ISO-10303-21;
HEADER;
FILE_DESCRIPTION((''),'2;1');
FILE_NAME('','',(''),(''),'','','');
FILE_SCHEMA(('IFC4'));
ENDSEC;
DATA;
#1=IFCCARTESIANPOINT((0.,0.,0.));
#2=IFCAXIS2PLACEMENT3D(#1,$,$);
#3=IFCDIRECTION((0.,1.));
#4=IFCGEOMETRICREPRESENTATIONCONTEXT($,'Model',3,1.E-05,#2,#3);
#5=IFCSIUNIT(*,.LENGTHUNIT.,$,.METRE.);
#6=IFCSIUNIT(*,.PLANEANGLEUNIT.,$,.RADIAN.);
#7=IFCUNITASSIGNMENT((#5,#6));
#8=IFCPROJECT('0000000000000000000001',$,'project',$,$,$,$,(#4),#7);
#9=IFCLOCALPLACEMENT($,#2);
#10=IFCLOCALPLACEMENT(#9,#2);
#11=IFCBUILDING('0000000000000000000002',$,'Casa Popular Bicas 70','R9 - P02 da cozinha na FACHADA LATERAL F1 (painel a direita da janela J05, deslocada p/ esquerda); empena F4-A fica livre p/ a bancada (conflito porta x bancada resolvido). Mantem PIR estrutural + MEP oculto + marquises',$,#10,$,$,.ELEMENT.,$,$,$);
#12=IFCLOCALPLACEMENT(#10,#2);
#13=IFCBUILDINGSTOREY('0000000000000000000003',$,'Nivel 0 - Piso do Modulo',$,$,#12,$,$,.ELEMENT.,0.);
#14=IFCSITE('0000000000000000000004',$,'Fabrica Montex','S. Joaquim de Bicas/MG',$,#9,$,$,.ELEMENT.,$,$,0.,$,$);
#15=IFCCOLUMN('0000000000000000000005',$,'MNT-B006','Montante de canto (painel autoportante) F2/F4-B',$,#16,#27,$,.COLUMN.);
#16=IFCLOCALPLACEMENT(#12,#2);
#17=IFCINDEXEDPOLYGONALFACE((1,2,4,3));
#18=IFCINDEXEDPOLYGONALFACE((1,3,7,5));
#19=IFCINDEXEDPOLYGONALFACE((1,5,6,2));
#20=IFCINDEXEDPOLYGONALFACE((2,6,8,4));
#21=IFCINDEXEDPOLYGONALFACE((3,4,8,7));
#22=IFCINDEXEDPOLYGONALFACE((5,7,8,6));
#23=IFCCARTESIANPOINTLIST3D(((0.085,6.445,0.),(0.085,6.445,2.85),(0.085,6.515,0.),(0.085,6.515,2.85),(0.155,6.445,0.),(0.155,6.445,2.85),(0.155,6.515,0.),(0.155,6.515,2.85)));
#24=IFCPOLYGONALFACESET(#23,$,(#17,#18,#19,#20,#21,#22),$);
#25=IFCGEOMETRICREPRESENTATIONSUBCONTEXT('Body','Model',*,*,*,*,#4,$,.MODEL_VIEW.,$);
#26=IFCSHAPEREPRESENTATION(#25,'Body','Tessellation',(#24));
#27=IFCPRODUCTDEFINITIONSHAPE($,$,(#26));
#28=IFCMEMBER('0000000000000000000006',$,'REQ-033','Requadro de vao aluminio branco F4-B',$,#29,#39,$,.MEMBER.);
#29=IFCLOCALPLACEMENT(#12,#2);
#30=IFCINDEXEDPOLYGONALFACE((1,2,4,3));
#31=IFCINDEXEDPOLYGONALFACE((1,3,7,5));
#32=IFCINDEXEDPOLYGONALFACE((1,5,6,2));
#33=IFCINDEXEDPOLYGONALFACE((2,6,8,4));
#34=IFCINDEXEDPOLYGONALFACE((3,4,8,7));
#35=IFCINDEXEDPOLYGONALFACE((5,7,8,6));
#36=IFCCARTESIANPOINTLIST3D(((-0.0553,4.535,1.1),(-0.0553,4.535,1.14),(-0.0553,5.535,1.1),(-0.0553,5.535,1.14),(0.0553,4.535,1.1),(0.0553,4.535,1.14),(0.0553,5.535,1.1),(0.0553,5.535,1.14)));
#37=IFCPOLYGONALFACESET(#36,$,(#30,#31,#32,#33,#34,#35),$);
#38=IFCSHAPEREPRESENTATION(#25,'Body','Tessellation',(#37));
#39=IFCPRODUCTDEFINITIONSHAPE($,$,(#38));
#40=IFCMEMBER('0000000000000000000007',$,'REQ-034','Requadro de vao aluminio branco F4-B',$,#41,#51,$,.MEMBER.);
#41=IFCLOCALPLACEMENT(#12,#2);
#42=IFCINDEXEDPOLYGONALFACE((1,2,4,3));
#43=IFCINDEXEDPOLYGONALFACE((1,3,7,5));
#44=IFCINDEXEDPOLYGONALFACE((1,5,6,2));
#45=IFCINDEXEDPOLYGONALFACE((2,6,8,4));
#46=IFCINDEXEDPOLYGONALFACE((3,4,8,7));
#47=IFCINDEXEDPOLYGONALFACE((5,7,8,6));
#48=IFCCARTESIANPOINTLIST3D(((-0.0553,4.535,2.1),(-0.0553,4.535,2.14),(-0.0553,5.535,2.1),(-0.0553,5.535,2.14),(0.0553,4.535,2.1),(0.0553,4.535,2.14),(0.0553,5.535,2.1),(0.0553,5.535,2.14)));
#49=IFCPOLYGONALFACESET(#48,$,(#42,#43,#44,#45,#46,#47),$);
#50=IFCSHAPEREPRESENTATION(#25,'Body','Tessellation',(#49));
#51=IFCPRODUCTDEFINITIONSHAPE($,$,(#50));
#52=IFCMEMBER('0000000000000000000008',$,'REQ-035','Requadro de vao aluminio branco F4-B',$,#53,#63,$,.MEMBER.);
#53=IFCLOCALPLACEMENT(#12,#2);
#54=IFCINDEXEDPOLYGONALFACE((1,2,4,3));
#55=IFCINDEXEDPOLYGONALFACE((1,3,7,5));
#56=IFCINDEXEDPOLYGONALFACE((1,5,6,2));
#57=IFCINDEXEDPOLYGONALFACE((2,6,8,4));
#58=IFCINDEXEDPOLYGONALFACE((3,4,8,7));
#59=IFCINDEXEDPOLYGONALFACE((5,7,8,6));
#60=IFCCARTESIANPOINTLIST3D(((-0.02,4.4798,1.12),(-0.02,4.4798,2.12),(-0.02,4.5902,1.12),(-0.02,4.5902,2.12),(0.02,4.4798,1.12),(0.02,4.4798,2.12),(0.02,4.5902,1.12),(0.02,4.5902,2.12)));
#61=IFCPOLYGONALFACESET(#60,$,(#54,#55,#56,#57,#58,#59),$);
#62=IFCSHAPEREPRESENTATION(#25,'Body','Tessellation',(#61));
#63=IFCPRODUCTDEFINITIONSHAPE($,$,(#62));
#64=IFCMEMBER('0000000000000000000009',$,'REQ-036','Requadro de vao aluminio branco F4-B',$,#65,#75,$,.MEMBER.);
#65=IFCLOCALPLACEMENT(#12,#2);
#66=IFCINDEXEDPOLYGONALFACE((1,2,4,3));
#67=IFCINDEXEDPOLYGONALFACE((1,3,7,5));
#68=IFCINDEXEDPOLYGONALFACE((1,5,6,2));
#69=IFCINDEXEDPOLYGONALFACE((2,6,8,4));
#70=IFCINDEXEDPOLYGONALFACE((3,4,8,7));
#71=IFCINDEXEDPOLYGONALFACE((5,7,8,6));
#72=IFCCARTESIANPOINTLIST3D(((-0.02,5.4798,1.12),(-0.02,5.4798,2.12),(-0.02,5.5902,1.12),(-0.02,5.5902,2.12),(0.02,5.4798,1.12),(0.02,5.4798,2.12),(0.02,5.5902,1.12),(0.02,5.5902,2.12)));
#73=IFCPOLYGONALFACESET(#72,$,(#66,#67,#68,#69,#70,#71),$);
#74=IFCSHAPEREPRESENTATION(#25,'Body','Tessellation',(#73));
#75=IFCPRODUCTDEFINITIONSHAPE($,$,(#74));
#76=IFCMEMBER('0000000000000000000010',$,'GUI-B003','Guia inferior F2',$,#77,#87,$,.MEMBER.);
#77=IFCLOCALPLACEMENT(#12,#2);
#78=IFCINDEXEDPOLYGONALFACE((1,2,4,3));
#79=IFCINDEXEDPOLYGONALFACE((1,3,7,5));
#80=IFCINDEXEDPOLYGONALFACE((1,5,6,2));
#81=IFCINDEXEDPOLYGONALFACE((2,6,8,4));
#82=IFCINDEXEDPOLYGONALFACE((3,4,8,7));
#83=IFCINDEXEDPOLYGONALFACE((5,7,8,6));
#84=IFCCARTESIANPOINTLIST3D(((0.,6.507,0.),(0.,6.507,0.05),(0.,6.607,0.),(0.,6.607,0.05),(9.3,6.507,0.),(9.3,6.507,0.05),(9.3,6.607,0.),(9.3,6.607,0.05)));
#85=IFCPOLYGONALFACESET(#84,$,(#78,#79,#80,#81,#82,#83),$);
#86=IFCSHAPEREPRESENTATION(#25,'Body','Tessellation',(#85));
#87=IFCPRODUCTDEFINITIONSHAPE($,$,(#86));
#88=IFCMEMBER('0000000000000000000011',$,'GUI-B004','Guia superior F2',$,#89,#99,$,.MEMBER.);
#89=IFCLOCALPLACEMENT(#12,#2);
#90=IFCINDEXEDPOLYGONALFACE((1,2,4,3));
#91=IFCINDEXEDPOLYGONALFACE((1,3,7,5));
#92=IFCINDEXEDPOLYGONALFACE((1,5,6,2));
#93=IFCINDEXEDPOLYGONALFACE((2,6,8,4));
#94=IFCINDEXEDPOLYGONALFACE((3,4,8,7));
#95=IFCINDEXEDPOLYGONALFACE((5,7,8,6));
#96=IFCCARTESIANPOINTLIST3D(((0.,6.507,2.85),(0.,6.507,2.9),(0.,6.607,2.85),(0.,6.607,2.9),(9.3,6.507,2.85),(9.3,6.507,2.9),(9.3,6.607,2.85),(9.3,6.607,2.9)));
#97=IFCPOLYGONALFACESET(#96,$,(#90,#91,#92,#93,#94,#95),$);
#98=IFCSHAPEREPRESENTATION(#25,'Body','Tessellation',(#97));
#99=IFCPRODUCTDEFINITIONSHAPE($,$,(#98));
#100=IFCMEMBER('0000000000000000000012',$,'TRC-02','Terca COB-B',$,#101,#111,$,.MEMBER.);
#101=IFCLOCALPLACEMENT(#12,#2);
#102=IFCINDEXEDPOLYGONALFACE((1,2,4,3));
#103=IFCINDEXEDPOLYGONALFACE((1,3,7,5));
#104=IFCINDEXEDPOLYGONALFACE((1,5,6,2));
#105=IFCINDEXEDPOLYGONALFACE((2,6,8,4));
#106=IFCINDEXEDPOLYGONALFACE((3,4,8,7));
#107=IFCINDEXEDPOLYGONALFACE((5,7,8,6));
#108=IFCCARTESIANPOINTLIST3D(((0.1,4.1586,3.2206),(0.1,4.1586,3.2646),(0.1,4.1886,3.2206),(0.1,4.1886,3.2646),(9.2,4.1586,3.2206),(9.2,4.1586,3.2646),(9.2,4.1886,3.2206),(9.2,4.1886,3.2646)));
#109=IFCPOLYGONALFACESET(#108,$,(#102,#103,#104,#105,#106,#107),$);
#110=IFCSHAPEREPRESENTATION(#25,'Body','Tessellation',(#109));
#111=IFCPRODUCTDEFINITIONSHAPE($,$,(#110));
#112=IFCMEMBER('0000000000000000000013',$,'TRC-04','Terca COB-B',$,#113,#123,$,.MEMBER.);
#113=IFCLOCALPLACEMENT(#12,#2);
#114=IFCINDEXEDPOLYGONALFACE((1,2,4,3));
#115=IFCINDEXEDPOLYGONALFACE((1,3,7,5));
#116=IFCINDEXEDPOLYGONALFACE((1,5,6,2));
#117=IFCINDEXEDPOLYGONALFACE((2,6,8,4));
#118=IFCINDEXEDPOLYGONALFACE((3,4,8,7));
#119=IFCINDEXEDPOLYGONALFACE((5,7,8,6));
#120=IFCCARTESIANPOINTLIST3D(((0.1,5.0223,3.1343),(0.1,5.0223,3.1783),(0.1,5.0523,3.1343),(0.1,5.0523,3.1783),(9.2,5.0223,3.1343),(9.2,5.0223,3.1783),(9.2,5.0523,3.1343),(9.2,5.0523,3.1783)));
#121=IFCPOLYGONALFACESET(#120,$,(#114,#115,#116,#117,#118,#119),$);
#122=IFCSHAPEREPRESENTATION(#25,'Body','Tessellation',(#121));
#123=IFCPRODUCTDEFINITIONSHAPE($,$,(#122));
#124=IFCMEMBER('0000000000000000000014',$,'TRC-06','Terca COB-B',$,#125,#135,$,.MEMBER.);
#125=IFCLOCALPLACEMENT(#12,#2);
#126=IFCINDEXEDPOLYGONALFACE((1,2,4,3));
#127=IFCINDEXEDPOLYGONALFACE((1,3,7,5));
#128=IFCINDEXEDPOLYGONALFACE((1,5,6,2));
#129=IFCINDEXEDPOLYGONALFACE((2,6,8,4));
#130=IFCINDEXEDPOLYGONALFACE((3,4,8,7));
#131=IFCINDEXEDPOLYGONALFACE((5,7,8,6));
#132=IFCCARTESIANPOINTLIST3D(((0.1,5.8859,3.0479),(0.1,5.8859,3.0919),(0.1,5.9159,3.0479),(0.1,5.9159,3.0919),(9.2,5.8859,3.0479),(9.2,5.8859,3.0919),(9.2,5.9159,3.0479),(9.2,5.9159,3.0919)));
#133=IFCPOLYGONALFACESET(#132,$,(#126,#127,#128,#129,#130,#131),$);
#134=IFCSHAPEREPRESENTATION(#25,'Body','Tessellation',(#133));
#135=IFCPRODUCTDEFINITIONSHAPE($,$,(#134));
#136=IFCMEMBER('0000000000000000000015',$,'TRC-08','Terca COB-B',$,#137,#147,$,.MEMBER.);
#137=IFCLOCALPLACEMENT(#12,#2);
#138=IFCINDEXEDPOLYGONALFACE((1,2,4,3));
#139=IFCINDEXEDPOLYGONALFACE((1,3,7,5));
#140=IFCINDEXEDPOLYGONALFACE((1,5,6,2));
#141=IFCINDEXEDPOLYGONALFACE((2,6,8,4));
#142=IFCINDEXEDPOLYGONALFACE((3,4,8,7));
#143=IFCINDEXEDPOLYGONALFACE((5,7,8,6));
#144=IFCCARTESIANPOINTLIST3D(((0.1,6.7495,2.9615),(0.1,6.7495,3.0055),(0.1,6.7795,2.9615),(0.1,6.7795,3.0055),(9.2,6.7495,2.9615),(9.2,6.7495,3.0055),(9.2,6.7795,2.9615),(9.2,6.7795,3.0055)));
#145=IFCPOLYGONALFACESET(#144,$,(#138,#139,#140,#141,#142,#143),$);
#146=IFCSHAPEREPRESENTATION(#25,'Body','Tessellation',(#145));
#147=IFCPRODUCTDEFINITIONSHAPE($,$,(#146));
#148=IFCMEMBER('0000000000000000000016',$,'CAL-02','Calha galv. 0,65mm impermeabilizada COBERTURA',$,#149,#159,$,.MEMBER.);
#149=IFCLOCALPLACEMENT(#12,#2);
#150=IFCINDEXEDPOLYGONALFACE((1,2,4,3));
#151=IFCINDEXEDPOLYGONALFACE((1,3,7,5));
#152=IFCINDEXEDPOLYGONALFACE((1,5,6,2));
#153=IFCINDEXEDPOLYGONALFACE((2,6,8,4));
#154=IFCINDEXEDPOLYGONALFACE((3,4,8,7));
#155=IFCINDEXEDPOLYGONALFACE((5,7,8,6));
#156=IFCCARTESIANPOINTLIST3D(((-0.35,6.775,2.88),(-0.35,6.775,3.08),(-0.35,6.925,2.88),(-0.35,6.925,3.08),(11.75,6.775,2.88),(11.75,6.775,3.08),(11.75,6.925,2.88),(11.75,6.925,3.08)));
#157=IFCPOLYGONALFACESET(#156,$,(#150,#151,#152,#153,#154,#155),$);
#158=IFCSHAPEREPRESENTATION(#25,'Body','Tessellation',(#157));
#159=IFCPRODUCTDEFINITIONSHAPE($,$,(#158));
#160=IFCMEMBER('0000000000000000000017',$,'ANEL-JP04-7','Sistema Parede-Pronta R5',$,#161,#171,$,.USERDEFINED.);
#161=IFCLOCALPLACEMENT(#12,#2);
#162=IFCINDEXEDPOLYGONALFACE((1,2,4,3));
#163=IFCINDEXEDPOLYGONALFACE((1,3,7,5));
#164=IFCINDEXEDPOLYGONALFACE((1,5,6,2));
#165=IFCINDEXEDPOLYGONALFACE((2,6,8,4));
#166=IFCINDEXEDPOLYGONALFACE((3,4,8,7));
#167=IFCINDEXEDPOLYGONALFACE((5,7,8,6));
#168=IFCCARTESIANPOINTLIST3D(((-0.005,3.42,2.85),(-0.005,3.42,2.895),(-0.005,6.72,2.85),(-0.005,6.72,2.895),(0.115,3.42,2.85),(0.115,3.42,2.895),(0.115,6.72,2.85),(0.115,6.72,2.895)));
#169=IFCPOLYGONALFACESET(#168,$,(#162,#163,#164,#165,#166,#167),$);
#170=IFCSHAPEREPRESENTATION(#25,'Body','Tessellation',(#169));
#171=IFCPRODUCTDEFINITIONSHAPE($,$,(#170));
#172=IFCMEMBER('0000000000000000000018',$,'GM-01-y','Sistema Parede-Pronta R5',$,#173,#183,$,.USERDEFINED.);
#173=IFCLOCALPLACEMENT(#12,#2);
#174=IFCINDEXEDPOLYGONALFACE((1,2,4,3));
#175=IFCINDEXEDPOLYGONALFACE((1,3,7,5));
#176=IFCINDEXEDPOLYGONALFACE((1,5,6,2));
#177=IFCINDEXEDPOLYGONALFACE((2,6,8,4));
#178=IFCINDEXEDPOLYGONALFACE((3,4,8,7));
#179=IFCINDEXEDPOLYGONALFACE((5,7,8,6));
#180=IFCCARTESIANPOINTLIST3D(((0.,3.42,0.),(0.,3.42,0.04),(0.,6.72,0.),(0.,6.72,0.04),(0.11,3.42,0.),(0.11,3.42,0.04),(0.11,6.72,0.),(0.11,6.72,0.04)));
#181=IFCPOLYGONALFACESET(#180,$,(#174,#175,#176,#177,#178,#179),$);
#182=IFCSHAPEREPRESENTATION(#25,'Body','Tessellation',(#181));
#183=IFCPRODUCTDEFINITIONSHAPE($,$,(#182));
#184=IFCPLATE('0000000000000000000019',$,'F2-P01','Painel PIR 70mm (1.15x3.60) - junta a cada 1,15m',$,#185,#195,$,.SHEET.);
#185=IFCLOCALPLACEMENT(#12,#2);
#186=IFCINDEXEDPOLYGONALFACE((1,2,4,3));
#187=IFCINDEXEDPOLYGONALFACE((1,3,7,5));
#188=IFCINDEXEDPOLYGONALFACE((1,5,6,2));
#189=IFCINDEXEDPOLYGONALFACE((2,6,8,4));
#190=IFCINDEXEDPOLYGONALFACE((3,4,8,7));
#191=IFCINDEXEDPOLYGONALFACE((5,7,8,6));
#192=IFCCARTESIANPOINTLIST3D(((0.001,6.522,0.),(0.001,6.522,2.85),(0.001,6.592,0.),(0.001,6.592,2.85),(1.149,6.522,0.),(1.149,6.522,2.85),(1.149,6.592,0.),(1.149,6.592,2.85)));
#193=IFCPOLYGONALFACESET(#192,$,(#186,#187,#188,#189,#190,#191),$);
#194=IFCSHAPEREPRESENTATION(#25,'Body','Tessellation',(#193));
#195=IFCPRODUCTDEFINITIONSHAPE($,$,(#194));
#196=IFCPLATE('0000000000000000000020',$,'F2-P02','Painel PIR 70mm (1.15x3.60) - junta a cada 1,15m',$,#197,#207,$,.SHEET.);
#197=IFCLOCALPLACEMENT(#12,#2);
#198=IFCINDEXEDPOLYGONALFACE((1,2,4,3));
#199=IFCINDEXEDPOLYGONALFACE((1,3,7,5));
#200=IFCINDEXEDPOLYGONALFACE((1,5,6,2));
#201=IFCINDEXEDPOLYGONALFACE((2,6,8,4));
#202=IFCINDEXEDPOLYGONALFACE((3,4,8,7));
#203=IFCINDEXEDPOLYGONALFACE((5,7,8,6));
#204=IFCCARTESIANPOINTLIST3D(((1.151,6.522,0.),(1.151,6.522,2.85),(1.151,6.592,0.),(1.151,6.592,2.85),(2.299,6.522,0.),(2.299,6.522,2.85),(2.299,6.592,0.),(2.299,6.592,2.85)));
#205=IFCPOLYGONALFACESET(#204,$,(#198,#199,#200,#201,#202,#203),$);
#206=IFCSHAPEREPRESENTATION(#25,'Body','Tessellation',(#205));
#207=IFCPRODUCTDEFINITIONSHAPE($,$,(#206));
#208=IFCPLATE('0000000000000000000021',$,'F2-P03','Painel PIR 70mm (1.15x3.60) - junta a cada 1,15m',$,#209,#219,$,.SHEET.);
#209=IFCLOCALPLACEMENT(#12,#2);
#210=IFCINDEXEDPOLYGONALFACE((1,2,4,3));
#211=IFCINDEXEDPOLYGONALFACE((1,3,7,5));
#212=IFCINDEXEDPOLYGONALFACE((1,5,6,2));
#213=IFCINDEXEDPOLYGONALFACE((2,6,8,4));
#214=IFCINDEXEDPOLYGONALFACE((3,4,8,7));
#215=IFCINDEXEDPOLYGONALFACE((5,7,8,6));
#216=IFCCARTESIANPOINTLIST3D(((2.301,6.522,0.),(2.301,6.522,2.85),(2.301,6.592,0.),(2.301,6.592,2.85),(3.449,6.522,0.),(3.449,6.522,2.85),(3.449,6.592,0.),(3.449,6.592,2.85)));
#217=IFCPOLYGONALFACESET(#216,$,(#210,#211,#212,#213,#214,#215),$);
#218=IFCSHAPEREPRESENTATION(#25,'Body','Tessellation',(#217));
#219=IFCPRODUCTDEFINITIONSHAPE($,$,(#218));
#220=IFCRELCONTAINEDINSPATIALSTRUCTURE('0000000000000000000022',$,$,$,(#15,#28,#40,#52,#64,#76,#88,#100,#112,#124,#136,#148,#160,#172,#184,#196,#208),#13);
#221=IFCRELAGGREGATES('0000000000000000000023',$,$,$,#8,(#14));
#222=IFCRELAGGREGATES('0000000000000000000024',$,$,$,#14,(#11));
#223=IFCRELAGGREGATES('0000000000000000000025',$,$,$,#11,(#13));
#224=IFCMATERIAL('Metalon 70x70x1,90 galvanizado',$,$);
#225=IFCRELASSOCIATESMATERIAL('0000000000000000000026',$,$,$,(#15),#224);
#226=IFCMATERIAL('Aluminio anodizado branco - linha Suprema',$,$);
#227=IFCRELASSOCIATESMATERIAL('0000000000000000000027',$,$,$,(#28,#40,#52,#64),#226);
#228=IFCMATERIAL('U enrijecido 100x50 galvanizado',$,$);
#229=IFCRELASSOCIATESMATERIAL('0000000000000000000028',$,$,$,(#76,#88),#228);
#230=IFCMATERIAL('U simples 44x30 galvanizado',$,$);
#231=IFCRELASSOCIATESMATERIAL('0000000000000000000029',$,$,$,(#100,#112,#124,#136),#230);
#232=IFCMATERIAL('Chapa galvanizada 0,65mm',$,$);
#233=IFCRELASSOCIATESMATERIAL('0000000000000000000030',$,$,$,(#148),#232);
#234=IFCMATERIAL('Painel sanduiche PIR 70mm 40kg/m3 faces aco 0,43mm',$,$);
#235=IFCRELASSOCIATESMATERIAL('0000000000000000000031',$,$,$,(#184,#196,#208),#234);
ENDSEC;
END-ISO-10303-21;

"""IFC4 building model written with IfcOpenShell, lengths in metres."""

from ifc_helpers import new_model, si_unit, direction, frame, frame_2d, origin, origin_2d, place, context, subcontext, project, spatial, rectangle, extrude, material, element, save


model = new_model("IFC4")

# Units and contexts
model_context = context("Model", 3, precision=1e-05, world=origin(), true_north=direction((0.0, 1.0)))
body_context = subcontext(model_context, "Body", "Model", "MODEL_VIEW")
ifc_project = project(units=[si_unit("LENGTHUNIT", "METRE"), si_unit("PLANEANGLEUNIT", "RADIAN")], contexts=[model_context])

# Site, building, storey
site_placement = place(None, origin())
site = spatial("IfcSite", under=ifc_project, at=site_placement, Name="Fabrica Montex", Description="S. Joaquim de Bicas/MG", CompositionType="ELEMENT", RefElevation=0.0)
building_placement = place(site_placement, origin())
building = spatial("IfcBuilding", under=site, at=building_placement, Name="Casa Popular Bicas 70", Description="R9 - P02 da cozinha na FACHADA LATERAL F1 (painel a direita da janela J05, deslocada p/ esquerda); empena F4-A fica livre p/ a bancada (conflito porta x bancada resolvido). Mantem PIR estrutural + MEP oculto + marquises", CompositionType="ELEMENT")
storey_placement = place(building_placement, origin())
storey = spatial("IfcBuildingStorey", under=building, at=storey_placement, Name="Nivel 0 - Piso do Modulo", CompositionType="ELEMENT", Elevation=0.0)

# Column
ifc_material_1 = material(Name="Metalon 70x70x1,90 galvanizado")
column_placement = place(storey_placement, frame((0.12, 6.48, 0.0)))
element("IfcColumn", 1, at=column_placement, inside=storey, material=ifc_material_1, Name="MNT-B006", Description="Montante de canto (painel autoportante) F2/F4-B", PredefinedType="COLUMN", context=body_context, shape_type="SweptSolid", body=[
    extrude(rectangle(XDim=0.07, YDim=0.07, at=origin_2d()), origin(), (0.0, 0.0, 1.0), 2.85),
])

# Members
ifc_material_2 = material(Name="Aluminio anodizado branco - linha Suprema")
for number, where, z_axis, x_axis, name in (
    (2, (0.0, 4.535, 1.12), (0.0, 1.0, 0.0), (0.0, 0.0, 1.0), "REQ-033"),
    (3, (0.0, 4.535, 2.12), (0.0, 1.0, 0.0), (0.0, 0.0, 1.0), "REQ-034"),
    (4, (0.0, 4.535, 1.12), (0.0, 0.0, 1.0), (1.0, 0.0, 0.0), "REQ-035"),
    (5, (0.0, 5.535, 1.12), (0.0, 0.0, 1.0), (1.0, 0.0, 0.0), "REQ-036"),
):
    element("IfcMember", number, at=place(storey_placement, frame(where, z_axis=z_axis, x_axis=x_axis)), inside=storey, material=ifc_material_2, Name=name, Description="Requadro de vao aluminio branco F4-B", PredefinedType="MEMBER", context=body_context, shape_type="SweptSolid", body=[
        extrude(rectangle(XDim=0.04, YDim=0.1105, at=origin_2d()), origin(), (0.0, 0.0, 1.0), 1.0),
    ])
ifc_material_3 = material(Name="U enrijecido 100x50 galvanizado")
for number, where, z_axis, x_axis, name, description in (
    (6, (0.0, 6.557, 0.025), (1.0, 0.0, 0.0), (0.0, 0.0, 1.0), "GUI-B003", "Guia inferior F2"),
    (7, (0.0, 6.557, 2.875), (1.0, 0.0, 0.0), (0.0, 0.0, 1.0), "GUI-B004", "Guia superior F2"),
):
    element("IfcMember", number, at=place(storey_placement, frame(where, z_axis=z_axis, x_axis=x_axis)), inside=storey, material=ifc_material_3, Name=name, Description=description, PredefinedType="MEMBER", context=body_context, shape_type="SweptSolid", body=[
        extrude(rectangle(XDim=0.05, YDim=0.1, at=origin_2d()), origin(), (0.0, 0.0, 1.0), 9.3),
    ])
ifc_material_4 = material(Name="U simples 44x30 galvanizado")
for number, where, z_axis, x_axis, name in (
    (8, (0.1, 4.1736, 3.2426), (1.0, 0.0, 0.0), (0.0, 0.0, 1.0), "TRC-02"),
    (9, (0.1, 5.0373, 3.1563), (1.0, 0.0, 0.0), (0.0, 0.0, 1.0), "TRC-04"),
    (10, (0.1, 5.9009, 3.0699), (1.0, 0.0, 0.0), (0.0, 0.0, 1.0), "TRC-06"),
    (11, (0.1, 6.7645, 2.9835), (1.0, 0.0, 0.0), (0.0, 0.0, 1.0), "TRC-08"),
):
    element("IfcMember", number, at=place(storey_placement, frame(where, z_axis=z_axis, x_axis=x_axis)), inside=storey, material=ifc_material_4, Name=name, Description="Terca COB-B", PredefinedType="MEMBER", context=body_context, shape_type="SweptSolid", body=[
        extrude(rectangle(XDim=0.044, YDim=0.03, at=origin_2d()), origin(), (0.0, 0.0, 1.0), 9.1),
    ])
ifc_material_5 = material(Name="Chapa galvanizada 0,65mm")
member_1_placement = place(storey_placement, frame((-0.35, 6.85, 2.98), z_axis=(1.0, 0.0, 0.0), x_axis=(0.0, 0.0, 1.0)))
element("IfcMember", 12, at=member_1_placement, inside=storey, material=ifc_material_5, Name="CAL-02", Description="Calha galv. 0,65mm impermeabilizada COBERTURA", PredefinedType="MEMBER", context=body_context, shape_type="SweptSolid", body=[
    extrude(rectangle(XDim=0.2, YDim=0.15, at=origin_2d()), origin(), (0.0, 0.0, 1.0), 12.1),
])
member_2_placement = place(storey_placement, frame((0.055, 5.07, 2.85)))
element("IfcMember", 13, at=member_2_placement, inside=storey, Name="ANEL-JP04-7", Description="Sistema Parede-Pronta R5", PredefinedType="USERDEFINED", context=body_context, shape_type="SweptSolid", body=[
    extrude(rectangle(XDim=0.12, YDim=3.3, at=origin_2d()), origin(), (0.0, 0.0, 1.0), 0.045),
])
member_3_placement = place(storey_placement, frame((0.055, 5.07, 0.0)))
element("IfcMember", 14, at=member_3_placement, inside=storey, Name="GM-01-y", Description="Sistema Parede-Pronta R5", PredefinedType="USERDEFINED", context=body_context, shape_type="SweptSolid", body=[
    extrude(rectangle(XDim=0.11, YDim=3.3, at=origin_2d()), origin(), (0.0, 0.0, 1.0), 0.04),
])

# Plates
ifc_material_6 = material(Name="Painel sanduiche PIR 70mm 40kg/m3 faces aco 0,43mm")
for number, where, x_axis, name in (
    (15, (0.001, 6.557, 0.0), (1.0, 0.0, 0.0), "F2-P01"),
    (16, (1.151, 6.557, 0.0), (1.0, 0.0, 0.0), "F2-P02"),
    (17, (2.301, 6.557, 0.0), (1.0, 0.0, 0.0), "F2-P03"),
):
    element("IfcPlate", number, at=place(storey_placement, frame(where, x_axis=x_axis)), inside=storey, material=ifc_material_6, Name=name, Description="Painel PIR 70mm (1.15x3.60) - junta a cada 1,15m", PredefinedType="SHEET", context=body_context, shape_type="SweptSolid", body=[
        extrude(rectangle(XDim=1.148, YDim=0.07, at=frame_2d((0.574, 0.0))), origin(), (0.0, 0.0, 1.0), 2.85),
    ])

save(model, "model.ifc")
